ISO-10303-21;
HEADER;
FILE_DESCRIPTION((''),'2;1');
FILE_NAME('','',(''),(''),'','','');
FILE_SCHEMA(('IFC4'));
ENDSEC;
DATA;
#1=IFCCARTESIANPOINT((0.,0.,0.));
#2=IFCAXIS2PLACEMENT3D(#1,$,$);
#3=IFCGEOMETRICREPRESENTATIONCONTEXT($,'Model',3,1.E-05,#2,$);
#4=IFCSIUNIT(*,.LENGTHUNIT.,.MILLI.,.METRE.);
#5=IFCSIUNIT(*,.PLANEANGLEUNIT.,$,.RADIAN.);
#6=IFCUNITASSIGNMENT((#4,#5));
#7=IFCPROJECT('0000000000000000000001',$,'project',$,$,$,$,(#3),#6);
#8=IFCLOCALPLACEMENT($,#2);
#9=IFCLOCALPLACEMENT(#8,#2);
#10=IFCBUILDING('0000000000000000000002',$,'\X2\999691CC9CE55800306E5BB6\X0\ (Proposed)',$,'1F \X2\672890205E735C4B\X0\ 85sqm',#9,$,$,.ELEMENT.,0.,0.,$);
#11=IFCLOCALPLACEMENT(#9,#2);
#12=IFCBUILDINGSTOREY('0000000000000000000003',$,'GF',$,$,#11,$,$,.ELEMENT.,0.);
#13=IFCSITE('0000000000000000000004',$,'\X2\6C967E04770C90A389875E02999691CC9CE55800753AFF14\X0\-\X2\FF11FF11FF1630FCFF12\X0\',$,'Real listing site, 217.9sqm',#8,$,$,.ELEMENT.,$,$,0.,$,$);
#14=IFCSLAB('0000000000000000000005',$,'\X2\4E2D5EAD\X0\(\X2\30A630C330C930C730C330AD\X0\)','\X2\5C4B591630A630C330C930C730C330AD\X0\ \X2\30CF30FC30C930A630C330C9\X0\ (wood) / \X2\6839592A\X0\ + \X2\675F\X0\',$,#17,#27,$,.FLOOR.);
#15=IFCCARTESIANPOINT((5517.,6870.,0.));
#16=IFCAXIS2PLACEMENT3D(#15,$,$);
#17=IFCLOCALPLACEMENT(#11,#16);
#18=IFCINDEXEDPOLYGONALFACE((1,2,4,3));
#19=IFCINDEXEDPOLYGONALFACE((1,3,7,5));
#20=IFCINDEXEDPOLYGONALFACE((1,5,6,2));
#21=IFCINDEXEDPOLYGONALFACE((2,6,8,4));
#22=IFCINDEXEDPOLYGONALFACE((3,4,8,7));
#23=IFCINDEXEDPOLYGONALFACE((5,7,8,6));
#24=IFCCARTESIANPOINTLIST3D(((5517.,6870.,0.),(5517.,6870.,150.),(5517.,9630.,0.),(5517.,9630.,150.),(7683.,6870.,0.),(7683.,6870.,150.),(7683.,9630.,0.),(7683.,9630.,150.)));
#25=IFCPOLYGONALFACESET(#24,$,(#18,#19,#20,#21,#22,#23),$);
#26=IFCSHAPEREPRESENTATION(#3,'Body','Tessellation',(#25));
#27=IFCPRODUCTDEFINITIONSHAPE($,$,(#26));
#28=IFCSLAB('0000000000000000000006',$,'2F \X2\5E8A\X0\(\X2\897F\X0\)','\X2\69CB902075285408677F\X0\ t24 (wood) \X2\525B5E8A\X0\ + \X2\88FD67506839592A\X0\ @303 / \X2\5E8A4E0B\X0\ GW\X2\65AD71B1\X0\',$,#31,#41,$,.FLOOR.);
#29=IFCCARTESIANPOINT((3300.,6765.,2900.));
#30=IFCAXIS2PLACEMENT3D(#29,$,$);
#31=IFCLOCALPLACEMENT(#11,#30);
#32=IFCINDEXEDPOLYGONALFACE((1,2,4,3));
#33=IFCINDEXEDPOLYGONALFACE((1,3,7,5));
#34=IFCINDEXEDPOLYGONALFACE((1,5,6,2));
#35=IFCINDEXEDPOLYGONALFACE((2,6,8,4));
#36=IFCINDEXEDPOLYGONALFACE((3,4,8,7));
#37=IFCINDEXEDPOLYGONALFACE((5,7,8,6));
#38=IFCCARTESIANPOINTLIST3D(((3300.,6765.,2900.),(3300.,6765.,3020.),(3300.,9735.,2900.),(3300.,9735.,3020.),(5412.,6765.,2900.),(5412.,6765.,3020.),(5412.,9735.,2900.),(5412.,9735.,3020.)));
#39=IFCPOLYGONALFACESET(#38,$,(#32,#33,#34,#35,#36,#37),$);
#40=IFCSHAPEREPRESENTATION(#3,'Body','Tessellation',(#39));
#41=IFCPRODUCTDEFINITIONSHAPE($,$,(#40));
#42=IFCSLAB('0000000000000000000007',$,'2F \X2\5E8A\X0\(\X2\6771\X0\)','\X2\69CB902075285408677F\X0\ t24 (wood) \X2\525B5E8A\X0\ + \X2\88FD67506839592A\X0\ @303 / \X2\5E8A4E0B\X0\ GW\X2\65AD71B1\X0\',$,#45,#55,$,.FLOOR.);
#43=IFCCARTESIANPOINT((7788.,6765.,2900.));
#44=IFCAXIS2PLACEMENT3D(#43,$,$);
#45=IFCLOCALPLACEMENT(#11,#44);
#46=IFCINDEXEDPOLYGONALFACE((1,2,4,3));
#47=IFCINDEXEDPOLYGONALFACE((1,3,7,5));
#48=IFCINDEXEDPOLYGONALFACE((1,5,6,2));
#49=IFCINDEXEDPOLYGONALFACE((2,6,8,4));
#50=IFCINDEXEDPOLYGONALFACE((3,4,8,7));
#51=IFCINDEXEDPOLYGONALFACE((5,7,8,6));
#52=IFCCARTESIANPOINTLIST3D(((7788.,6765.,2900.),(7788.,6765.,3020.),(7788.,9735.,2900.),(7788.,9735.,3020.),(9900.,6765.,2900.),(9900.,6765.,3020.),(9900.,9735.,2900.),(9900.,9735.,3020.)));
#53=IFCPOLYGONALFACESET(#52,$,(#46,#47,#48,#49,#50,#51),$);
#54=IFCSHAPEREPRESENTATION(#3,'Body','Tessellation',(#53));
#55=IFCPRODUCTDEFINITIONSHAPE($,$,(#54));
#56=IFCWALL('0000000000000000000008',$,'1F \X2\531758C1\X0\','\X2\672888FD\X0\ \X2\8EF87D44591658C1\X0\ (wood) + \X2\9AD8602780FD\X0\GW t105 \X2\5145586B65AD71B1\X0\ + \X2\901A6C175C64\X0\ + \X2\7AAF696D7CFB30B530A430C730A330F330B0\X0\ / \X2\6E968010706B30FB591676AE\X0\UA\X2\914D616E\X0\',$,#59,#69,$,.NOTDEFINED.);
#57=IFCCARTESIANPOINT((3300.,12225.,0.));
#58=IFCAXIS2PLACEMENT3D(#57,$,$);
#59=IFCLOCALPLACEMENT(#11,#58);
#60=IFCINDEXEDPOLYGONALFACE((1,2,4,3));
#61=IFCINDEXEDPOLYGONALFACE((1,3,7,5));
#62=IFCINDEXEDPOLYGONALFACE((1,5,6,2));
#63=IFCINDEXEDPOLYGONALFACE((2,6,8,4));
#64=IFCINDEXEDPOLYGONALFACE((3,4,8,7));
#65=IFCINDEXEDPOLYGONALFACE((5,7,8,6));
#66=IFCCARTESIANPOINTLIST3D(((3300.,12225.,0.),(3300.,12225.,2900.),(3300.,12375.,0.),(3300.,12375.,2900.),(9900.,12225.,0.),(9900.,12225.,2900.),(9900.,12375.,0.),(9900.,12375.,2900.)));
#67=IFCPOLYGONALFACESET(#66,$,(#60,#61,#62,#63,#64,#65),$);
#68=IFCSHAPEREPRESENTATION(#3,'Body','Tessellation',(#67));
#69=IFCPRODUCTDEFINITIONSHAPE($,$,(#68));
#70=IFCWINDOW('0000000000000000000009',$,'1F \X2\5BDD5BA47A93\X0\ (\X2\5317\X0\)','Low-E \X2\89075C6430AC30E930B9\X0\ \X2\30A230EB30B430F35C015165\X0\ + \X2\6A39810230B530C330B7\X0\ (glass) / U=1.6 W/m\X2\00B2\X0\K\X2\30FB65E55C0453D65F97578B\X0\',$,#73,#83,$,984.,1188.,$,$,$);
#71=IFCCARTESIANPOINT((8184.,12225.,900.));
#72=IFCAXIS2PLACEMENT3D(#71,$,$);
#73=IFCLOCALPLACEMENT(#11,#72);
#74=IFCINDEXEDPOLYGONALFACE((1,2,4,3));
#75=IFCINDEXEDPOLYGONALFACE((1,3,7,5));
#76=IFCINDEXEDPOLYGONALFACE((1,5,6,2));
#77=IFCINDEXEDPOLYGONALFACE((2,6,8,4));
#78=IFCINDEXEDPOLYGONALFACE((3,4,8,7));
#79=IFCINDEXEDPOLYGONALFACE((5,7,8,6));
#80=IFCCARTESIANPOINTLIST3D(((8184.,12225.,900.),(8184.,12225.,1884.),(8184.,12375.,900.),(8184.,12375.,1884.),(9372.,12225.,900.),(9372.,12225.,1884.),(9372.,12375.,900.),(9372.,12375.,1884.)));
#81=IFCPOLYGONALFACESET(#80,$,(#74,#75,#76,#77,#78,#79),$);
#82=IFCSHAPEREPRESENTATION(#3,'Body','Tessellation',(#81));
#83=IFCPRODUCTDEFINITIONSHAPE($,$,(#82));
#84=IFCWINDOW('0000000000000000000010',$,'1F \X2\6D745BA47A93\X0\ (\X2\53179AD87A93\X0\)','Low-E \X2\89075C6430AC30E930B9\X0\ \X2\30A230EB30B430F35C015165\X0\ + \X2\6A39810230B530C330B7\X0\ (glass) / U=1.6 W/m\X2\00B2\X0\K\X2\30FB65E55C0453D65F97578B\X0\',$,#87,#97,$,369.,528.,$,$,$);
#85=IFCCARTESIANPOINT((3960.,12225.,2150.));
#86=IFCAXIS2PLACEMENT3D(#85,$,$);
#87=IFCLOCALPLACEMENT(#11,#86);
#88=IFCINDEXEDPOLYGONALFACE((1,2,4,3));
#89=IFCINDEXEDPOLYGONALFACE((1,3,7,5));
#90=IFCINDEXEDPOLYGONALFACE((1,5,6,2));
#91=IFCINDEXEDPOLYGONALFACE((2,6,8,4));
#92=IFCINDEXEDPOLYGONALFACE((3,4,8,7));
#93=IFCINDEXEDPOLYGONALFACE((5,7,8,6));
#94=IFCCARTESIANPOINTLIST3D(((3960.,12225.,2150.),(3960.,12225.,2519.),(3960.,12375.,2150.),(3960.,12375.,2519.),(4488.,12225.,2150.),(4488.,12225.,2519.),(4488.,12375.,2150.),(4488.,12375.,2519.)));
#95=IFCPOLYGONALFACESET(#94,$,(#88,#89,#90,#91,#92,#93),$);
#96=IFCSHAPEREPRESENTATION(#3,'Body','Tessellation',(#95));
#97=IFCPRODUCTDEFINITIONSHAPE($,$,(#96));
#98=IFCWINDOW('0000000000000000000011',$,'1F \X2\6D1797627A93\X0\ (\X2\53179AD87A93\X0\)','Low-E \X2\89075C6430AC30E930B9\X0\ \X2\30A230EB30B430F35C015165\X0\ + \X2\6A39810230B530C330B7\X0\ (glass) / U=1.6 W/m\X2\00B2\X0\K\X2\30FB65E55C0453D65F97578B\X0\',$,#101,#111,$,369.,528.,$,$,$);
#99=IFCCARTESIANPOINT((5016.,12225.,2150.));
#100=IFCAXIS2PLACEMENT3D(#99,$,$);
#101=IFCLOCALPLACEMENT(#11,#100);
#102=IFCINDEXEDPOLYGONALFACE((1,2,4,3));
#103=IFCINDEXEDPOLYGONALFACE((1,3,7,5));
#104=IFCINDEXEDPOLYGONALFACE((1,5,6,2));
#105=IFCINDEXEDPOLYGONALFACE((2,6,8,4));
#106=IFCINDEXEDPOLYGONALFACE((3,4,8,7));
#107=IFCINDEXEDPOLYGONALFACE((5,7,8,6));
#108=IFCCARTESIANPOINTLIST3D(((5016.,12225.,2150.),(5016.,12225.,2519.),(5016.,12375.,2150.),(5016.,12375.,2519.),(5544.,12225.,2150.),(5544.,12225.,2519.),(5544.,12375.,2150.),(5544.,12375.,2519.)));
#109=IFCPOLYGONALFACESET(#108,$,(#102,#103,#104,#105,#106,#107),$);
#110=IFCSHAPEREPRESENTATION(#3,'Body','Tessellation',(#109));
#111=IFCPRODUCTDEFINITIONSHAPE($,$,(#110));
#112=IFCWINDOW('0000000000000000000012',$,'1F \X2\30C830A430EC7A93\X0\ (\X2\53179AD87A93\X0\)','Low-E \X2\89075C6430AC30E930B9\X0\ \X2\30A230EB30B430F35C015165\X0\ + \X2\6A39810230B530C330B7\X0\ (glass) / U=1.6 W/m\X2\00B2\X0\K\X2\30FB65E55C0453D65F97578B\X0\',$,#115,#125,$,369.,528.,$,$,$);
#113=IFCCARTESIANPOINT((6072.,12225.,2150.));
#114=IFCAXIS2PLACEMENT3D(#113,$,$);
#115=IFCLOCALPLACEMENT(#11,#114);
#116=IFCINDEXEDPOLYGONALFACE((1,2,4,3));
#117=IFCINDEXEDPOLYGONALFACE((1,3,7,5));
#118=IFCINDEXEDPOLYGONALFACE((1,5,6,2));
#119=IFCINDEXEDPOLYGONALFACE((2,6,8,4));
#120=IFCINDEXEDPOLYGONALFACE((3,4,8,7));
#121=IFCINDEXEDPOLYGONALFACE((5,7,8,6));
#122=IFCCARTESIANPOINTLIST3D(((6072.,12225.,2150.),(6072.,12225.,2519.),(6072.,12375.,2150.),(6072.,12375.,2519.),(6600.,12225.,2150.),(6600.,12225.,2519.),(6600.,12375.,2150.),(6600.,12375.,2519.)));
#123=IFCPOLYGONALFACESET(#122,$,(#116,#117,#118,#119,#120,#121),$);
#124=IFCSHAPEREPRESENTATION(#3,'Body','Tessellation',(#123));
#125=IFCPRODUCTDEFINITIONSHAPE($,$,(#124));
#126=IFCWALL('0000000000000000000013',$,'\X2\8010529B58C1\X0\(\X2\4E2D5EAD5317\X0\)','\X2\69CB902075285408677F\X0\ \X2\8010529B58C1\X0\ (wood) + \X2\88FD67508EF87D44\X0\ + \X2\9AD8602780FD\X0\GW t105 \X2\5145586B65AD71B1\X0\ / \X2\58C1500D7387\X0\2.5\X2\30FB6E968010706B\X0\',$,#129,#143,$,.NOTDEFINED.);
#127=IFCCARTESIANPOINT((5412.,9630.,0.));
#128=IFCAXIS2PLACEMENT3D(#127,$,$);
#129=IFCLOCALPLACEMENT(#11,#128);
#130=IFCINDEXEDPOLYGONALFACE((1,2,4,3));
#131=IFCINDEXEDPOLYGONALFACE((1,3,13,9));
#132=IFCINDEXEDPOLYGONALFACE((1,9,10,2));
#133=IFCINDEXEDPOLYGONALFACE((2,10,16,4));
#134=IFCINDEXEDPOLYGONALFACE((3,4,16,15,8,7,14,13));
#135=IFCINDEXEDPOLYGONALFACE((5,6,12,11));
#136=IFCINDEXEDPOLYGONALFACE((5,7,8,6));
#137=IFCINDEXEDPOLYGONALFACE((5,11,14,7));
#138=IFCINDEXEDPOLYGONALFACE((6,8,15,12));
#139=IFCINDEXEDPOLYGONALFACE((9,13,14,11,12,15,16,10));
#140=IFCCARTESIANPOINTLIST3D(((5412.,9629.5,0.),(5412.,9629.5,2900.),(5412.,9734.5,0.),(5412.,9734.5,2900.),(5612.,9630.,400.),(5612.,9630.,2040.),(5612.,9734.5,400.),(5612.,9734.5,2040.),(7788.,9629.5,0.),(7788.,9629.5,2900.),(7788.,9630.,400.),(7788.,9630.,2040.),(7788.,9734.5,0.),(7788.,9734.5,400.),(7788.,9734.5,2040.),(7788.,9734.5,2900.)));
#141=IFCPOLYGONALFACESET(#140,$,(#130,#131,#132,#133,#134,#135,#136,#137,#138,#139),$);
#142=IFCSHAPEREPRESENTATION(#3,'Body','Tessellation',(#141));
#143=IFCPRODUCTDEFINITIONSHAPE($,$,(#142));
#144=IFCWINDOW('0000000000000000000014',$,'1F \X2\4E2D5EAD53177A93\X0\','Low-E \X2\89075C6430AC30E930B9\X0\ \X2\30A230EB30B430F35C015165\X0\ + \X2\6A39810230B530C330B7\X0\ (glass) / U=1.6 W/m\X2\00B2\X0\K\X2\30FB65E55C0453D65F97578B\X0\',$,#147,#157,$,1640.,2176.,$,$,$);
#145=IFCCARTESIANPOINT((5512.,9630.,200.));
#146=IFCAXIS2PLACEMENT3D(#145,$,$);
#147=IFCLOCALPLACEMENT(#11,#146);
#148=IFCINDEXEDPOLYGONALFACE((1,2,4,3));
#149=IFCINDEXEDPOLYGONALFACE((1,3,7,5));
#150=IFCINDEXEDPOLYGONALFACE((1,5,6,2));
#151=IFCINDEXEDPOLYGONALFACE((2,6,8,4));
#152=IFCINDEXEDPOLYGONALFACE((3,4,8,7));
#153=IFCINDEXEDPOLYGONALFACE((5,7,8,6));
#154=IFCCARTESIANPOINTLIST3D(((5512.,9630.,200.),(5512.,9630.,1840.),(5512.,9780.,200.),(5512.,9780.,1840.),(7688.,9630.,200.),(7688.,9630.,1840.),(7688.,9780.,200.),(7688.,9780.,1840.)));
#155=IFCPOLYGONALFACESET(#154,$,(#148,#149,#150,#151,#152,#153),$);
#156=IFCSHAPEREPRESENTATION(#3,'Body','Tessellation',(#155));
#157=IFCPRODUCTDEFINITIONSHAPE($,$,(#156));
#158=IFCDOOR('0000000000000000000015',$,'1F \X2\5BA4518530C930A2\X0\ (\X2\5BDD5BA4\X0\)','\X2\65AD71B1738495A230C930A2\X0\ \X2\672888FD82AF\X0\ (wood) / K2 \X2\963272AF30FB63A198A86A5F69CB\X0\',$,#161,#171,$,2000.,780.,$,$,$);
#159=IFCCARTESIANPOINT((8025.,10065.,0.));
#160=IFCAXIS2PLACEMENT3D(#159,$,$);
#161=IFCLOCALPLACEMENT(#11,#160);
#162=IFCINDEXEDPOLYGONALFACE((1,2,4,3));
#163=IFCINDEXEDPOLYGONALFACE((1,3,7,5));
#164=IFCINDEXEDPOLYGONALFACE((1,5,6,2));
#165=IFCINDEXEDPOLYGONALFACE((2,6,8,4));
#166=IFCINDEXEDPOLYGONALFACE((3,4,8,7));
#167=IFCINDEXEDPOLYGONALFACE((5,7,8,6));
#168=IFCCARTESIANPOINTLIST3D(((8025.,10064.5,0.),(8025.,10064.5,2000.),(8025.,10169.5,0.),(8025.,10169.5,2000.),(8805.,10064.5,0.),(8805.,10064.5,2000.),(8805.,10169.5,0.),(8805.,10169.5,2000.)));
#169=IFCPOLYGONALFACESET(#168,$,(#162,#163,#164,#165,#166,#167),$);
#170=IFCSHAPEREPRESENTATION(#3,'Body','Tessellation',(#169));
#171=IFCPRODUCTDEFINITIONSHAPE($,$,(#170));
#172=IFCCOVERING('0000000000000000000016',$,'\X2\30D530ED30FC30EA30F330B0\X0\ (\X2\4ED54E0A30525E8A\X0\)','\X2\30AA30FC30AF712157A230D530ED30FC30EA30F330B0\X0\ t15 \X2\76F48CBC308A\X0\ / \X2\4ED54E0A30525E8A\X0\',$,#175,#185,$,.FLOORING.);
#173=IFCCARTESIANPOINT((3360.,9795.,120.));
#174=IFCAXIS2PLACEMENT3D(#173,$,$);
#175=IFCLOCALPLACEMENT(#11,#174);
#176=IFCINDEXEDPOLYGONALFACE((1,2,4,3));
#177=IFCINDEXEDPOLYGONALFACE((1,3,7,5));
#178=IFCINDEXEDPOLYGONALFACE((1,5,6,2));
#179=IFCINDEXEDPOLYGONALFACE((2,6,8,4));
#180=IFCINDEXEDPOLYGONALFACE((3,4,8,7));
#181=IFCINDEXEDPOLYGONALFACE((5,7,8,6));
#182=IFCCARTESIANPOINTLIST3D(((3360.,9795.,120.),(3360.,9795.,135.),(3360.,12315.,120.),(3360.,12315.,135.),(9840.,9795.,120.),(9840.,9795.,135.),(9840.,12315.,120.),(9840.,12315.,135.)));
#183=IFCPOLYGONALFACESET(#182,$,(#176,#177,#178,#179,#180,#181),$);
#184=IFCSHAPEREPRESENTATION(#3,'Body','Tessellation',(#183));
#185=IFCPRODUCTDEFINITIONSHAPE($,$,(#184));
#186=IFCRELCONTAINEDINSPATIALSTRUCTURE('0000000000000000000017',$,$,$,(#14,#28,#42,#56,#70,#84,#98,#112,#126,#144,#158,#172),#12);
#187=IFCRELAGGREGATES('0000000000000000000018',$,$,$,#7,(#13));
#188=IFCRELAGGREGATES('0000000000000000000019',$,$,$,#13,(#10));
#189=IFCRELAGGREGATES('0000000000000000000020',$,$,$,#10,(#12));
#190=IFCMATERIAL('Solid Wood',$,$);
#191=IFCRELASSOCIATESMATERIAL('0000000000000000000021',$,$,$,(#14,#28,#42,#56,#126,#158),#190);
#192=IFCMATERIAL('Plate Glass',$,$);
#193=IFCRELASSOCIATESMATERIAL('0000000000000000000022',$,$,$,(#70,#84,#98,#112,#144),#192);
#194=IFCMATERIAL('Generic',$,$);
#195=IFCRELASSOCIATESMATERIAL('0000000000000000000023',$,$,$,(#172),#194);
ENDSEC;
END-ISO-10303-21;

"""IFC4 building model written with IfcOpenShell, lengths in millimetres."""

from ifc_helpers import new_model, si_unit, frame, frame_2d, origin, place, context, project, spatial, rectangle, extrude, material, element, fill, save


model = new_model("IFC4")

# Units and contexts
model_context = context("Model", 3, precision=1e-05, world=origin())
ifc_project = project(units=[si_unit("LENGTHUNIT", "METRE", prefix="MILLI"), si_unit("PLANEANGLEUNIT", "RADIAN")], contexts=[model_context])

# Site, building, storey
site_placement = place(None, origin())
site = spatial("IfcSite", under=ifc_project, at=site_placement, Name="沖縄県那覇市首里鳥堀町４-１１６ー２", ObjectType="Real listing site, 217.9sqm", CompositionType="ELEMENT", RefElevation=0.0)
building_placement = place(site_placement, origin())
building = spatial("IfcBuilding", under=site, at=building_placement, Name="首里鳥堀の家 (Proposed)", ObjectType="1F 木造平屋 85sqm", CompositionType="ELEMENT", ElevationOfRefHeight=0.0, ElevationOfTerrain=0.0)
storey_placement = place(building_placement, origin())
storey = spatial("IfcBuildingStorey", under=building, at=storey_placement, Name="GF", CompositionType="ELEMENT", Elevation=0.0)

# Slabs
ifc_material_1 = material(Name="Solid Wood")
slab_1_placement = place(storey_placement, frame((5517.0, 6870.0, 0.0)))
element("IfcSlab", 1, at=slab_1_placement, inside=storey, material=ifc_material_1, Name="中庭(ウッドデッキ)", Description="屋外ウッドデッキ ハードウッド (wood) / 根太 + 束", PredefinedType="FLOOR", context=model_context, shape_type="SweptSolid", body=[
    extrude(rectangle(XDim=2166.0, YDim=2760.0, at=frame_2d((1083.0, 1380.0))), frame((5517.0, 6870.0, 0.0)), (0.0, 0.0, 1.0), 150.0),
])
slab_2_placement = place(storey_placement, frame((3300.0, 6765.0, 2900.0)))
element("IfcSlab", 2, at=slab_2_placement, inside=storey, material=ifc_material_1, Name="2F 床(西)", Description="構造用合板 t24 (wood) 剛床 + 製材根太 @303 / 床下 GW断熱", PredefinedType="FLOOR", context=model_context, shape_type="SweptSolid", body=[
    extrude(rectangle(XDim=2112.0, YDim=2970.0, at=frame_2d((1056.0, 1485.0))), frame((3300.0, 6765.0, 2900.0)), (0.0, 0.0, 1.0), 120.0),
])
slab_3_placement = place(storey_placement, frame((7788.0, 6765.0, 2900.0)))
element("IfcSlab", 3, at=slab_3_placement, inside=storey, material=ifc_material_1, Name="2F 床(東)", Description="構造用合板 t24 (wood) 剛床 + 製材根太 @303 / 床下 GW断熱", PredefinedType="FLOOR", context=model_context, shape_type="SweptSolid", body=[
    extrude(rectangle(XDim=2112.0, YDim=2970.0, at=frame_2d((1056.0, 1485.0))), frame((7788.0, 6765.0, 2900.0)), (0.0, 0.0, 1.0), 120.0),
])

# Wall, openings, windows
wall_1_placement = place(storey_placement, frame((3300.0, 12225.0, 0.0)))
wall_1 = element("IfcWall", 4, at=wall_1_placement, inside=storey, material=ifc_material_1, Name="1F 北壁", Description="木製 軸組外壁 (wood) + 高性能GW t105 充填断熱 + 通気層 + 窯業系サイディング / 準耐火・外皮UA配慮", PredefinedType="NOTDEFINED", context=model_context, shape_type="SweptSolid", body=[
    extrude(rectangle(XDim=6600.0, YDim=150.0, at=frame_2d((3300.0, 75.0))), frame((3300.0, 12225.0, 0.0)), (0.0, 0.0, 1.0), 2900.0),
])
opening_1_placement = place(storey_placement, frame((8184.0, 12225.0, 900.0)))
opening_1 = element("IfcOpeningElement", 5, at=opening_1_placement, cuts=wall_1, PredefinedType="NOTDEFINED", context=model_context, shape_type="SweptSolid", body=[
    extrude(rectangle(XDim=1188.0, YDim=150.0, at=frame_2d((594.0, 75.0))), frame((8184.0, 12225.0, 900.0)), (0.0, 0.0, 1.0), 984.0),
])
opening_2_placement = place(storey_placement, frame((3960.0, 12225.0, 2150.0)))
opening_2 = element("IfcOpeningElement", 6, at=opening_2_placement, cuts=wall_1, PredefinedType="NOTDEFINED", context=model_context, shape_type="SweptSolid", body=[
    extrude(rectangle(XDim=528.0, YDim=150.0, at=frame_2d((264.0, 75.0))), frame((3960.0, 12225.0, 2150.0)), (0.0, 0.0, 1.0), 369.0),
])
opening_3_placement = place(storey_placement, frame((5016.0, 12225.0, 2150.0)))
opening_3 = element("IfcOpeningElement", 7, at=opening_3_placement, cuts=wall_1, PredefinedType="NOTDEFINED", context=model_context, shape_type="SweptSolid", body=[
    extrude(rectangle(XDim=528.0, YDim=150.0, at=frame_2d((264.0, 75.0))), frame((5016.0, 12225.0, 2150.0)), (0.0, 0.0, 1.0), 369.0),
])
opening_4_placement = place(storey_placement, frame((6072.0, 12225.0, 2150.0)))
opening_4 = element("IfcOpeningElement", 8, at=opening_4_placement, cuts=wall_1, PredefinedType="NOTDEFINED", context=model_context, shape_type="SweptSolid", body=[
    extrude(rectangle(XDim=528.0, YDim=150.0, at=frame_2d((264.0, 75.0))), frame((6072.0, 12225.0, 2150.0)), (0.0, 0.0, 1.0), 369.0),
])
ifc_material_2 = material(Name="Plate Glass")
window_1_placement = place(storey_placement, frame((8184.0, 12225.0, 900.0)))
window_1 = element("IfcWindow", 9, at=window_1_placement, inside=storey, material=ifc_material_2, Name="1F 寝室窓 (北)", Description="Low-E 複層ガラス アルゴン封入 + 樹脂サッシ (glass) / U=1.6 W/m²K・日射取得型", OverallHeight=984.0, OverallWidth=1188.0, context=model_context, shape_type="SweptSolid", body=[
    extrude(rectangle(XDim=1188.0, YDim=150.0, at=frame_2d((594.0, 75.0))), frame((8184.0, 12225.0, 900.0)), (0.0, 0.0, 1.0), 984.0),
])
fill(opening_1, window_1)
window_2_placement = place(storey_placement, frame((3960.0, 12225.0, 2150.0)))
window_2 = element("IfcWindow", 10, at=window_2_placement, inside=storey, material=ifc_material_2, Name="1F 浴室窓 (北高窓)", Description="Low-E 複層ガラス アルゴン封入 + 樹脂サッシ (glass) / U=1.6 W/m²K・日射取得型", OverallHeight=369.0, OverallWidth=528.0, context=model_context, shape_type="SweptSolid", body=[
    extrude(rectangle(XDim=528.0, YDim=150.0, at=frame_2d((264.0, 75.0))), frame((3960.0, 12225.0, 2150.0)), (0.0, 0.0, 1.0), 369.0),
])
fill(opening_2, window_2)
window_3_placement = place(storey_placement, frame((5016.0, 12225.0, 2150.0)))
window_3 = element("IfcWindow", 11, at=window_3_placement, inside=storey, material=ifc_material_2, Name="1F 洗面窓 (北高窓)", Description="Low-E 複層ガラス アルゴン封入 + 樹脂サッシ (glass) / U=1.6 W/m²K・日射取得型", OverallHeight=369.0, OverallWidth=528.0, context=model_context, shape_type="SweptSolid", body=[
    extrude(rectangle(XDim=528.0, YDim=150.0, at=frame_2d((264.0, 75.0))), frame((5016.0, 12225.0, 2150.0)), (0.0, 0.0, 1.0), 369.0),
])
fill(opening_3, window_3)
window_4_placement = place(storey_placement, frame((6072.0, 12225.0, 2150.0)))
window_4 = element("IfcWindow", 12, at=window_4_placement, inside=storey, material=ifc_material_2, Name="1F トイレ窓 (北高窓)", Description="Low-E 複層ガラス アルゴン封入 + 樹脂サッシ (glass) / U=1.6 W/m²K・日射取得型", OverallHeight=369.0, OverallWidth=528.0, context=model_context, shape_type="SweptSolid", body=[
    extrude(rectangle(XDim=528.0, YDim=150.0, at=frame_2d((264.0, 75.0))), frame((6072.0, 12225.0, 2150.0)), (0.0, 0.0, 1.0), 369.0),
])
fill(opening_4, window_4)

# Wall, opening, window
wall_2_placement = place(storey_placement, frame((5412.0, 9630.0, 0.0)))
wall_2 = element("IfcWall", 13, at=wall_2_placement, inside=storey, material=ifc_material_1, Name="耐力壁(中庭北)", Description="構造用合板 耐力壁 (wood) + 製材軸組 + 高性能GW t105 充填断熱 / 壁倍率2.5・準耐火", PredefinedType="NOTDEFINED", context=model_context, shape_type="SweptSolid", body=[
    extrude(rectangle(XDim=2376.0, YDim=105.0, at=frame_2d((1188.0, 52.0))), frame((5412.0, 9630.0, 0.0)), (0.0, 0.0, 1.0), 2900.0),
])
opening_5_placement = place(storey_placement, frame((5512.0, 9630.0, 200.0)))
opening_5 = element("IfcOpeningElement", 14, at=opening_5_placement, cuts=wall_2, PredefinedType="NOTDEFINED", context=model_context, shape_type="SweptSolid", body=[
    extrude(rectangle(XDim=2176.0, YDim=150.0, at=frame_2d((1088.0, 75.0))), frame((5512.0, 9630.0, 200.0)), (0.0, 0.0, 1.0), 1640.0),
])
window_5_placement = place(storey_placement, frame((5512.0, 9630.0, 200.0)))
window_5 = element("IfcWindow", 15, at=window_5_placement, inside=storey, material=ifc_material_2, Name="1F 中庭北窓", Description="Low-E 複層ガラス アルゴン封入 + 樹脂サッシ (glass) / U=1.6 W/m²K・日射取得型", OverallHeight=1640.0, OverallWidth=2176.0, context=model_context, shape_type="SweptSolid", body=[
    extrude(rectangle(XDim=2176.0, YDim=150.0, at=frame_2d((1088.0, 75.0))), frame((5512.0, 9630.0, 200.0)), (0.0, 0.0, 1.0), 1640.0),
])
fill(opening_5, window_5)

# Door
door_1_placement = place(storey_placement, frame((8025.0, 10065.0, 0.0)))
element("IfcDoor", 16, at=door_1_placement, inside=storey, material=ifc_material_1, Name="1F 室内ドア (寝室)", Description="断熱玄関ドア 木製芯 (wood) / K2 防犯・採風機構", OverallHeight=2000.0, OverallWidth=780.0, context=model_context, shape_type="SweptSolid", body=[
    extrude(rectangle(XDim=780.0, YDim=105.0, at=frame_2d((390.0, 52.0))), frame((8025.0, 10065.0, 0.0)), (0.0, 0.0, 1.0), 2000.0),
])

# Covering
ifc_material_3 = material(Name="Generic")
covering_1_placement = place(storey_placement, frame((3360.0, 9795.0, 120.0)))
element("IfcCovering", 17, at=covering_1_placement, inside=storey, material=ifc_material_3, Name="フローリング (仕上げ床)", Description="オーク無垢フローリング t15 直貼り / 仕上げ床", PredefinedType="FLOORING", context=model_context, shape_type="SweptSolid", body=[
    extrude(rectangle(XDim=6480.0, YDim=2520.0, at=frame_2d((3240.0, 1260.0))), frame((3360.0, 9795.0, 120.0)), (0.0, 0.0, 1.0), 15.0),
])

save(model, "model.ifc")
